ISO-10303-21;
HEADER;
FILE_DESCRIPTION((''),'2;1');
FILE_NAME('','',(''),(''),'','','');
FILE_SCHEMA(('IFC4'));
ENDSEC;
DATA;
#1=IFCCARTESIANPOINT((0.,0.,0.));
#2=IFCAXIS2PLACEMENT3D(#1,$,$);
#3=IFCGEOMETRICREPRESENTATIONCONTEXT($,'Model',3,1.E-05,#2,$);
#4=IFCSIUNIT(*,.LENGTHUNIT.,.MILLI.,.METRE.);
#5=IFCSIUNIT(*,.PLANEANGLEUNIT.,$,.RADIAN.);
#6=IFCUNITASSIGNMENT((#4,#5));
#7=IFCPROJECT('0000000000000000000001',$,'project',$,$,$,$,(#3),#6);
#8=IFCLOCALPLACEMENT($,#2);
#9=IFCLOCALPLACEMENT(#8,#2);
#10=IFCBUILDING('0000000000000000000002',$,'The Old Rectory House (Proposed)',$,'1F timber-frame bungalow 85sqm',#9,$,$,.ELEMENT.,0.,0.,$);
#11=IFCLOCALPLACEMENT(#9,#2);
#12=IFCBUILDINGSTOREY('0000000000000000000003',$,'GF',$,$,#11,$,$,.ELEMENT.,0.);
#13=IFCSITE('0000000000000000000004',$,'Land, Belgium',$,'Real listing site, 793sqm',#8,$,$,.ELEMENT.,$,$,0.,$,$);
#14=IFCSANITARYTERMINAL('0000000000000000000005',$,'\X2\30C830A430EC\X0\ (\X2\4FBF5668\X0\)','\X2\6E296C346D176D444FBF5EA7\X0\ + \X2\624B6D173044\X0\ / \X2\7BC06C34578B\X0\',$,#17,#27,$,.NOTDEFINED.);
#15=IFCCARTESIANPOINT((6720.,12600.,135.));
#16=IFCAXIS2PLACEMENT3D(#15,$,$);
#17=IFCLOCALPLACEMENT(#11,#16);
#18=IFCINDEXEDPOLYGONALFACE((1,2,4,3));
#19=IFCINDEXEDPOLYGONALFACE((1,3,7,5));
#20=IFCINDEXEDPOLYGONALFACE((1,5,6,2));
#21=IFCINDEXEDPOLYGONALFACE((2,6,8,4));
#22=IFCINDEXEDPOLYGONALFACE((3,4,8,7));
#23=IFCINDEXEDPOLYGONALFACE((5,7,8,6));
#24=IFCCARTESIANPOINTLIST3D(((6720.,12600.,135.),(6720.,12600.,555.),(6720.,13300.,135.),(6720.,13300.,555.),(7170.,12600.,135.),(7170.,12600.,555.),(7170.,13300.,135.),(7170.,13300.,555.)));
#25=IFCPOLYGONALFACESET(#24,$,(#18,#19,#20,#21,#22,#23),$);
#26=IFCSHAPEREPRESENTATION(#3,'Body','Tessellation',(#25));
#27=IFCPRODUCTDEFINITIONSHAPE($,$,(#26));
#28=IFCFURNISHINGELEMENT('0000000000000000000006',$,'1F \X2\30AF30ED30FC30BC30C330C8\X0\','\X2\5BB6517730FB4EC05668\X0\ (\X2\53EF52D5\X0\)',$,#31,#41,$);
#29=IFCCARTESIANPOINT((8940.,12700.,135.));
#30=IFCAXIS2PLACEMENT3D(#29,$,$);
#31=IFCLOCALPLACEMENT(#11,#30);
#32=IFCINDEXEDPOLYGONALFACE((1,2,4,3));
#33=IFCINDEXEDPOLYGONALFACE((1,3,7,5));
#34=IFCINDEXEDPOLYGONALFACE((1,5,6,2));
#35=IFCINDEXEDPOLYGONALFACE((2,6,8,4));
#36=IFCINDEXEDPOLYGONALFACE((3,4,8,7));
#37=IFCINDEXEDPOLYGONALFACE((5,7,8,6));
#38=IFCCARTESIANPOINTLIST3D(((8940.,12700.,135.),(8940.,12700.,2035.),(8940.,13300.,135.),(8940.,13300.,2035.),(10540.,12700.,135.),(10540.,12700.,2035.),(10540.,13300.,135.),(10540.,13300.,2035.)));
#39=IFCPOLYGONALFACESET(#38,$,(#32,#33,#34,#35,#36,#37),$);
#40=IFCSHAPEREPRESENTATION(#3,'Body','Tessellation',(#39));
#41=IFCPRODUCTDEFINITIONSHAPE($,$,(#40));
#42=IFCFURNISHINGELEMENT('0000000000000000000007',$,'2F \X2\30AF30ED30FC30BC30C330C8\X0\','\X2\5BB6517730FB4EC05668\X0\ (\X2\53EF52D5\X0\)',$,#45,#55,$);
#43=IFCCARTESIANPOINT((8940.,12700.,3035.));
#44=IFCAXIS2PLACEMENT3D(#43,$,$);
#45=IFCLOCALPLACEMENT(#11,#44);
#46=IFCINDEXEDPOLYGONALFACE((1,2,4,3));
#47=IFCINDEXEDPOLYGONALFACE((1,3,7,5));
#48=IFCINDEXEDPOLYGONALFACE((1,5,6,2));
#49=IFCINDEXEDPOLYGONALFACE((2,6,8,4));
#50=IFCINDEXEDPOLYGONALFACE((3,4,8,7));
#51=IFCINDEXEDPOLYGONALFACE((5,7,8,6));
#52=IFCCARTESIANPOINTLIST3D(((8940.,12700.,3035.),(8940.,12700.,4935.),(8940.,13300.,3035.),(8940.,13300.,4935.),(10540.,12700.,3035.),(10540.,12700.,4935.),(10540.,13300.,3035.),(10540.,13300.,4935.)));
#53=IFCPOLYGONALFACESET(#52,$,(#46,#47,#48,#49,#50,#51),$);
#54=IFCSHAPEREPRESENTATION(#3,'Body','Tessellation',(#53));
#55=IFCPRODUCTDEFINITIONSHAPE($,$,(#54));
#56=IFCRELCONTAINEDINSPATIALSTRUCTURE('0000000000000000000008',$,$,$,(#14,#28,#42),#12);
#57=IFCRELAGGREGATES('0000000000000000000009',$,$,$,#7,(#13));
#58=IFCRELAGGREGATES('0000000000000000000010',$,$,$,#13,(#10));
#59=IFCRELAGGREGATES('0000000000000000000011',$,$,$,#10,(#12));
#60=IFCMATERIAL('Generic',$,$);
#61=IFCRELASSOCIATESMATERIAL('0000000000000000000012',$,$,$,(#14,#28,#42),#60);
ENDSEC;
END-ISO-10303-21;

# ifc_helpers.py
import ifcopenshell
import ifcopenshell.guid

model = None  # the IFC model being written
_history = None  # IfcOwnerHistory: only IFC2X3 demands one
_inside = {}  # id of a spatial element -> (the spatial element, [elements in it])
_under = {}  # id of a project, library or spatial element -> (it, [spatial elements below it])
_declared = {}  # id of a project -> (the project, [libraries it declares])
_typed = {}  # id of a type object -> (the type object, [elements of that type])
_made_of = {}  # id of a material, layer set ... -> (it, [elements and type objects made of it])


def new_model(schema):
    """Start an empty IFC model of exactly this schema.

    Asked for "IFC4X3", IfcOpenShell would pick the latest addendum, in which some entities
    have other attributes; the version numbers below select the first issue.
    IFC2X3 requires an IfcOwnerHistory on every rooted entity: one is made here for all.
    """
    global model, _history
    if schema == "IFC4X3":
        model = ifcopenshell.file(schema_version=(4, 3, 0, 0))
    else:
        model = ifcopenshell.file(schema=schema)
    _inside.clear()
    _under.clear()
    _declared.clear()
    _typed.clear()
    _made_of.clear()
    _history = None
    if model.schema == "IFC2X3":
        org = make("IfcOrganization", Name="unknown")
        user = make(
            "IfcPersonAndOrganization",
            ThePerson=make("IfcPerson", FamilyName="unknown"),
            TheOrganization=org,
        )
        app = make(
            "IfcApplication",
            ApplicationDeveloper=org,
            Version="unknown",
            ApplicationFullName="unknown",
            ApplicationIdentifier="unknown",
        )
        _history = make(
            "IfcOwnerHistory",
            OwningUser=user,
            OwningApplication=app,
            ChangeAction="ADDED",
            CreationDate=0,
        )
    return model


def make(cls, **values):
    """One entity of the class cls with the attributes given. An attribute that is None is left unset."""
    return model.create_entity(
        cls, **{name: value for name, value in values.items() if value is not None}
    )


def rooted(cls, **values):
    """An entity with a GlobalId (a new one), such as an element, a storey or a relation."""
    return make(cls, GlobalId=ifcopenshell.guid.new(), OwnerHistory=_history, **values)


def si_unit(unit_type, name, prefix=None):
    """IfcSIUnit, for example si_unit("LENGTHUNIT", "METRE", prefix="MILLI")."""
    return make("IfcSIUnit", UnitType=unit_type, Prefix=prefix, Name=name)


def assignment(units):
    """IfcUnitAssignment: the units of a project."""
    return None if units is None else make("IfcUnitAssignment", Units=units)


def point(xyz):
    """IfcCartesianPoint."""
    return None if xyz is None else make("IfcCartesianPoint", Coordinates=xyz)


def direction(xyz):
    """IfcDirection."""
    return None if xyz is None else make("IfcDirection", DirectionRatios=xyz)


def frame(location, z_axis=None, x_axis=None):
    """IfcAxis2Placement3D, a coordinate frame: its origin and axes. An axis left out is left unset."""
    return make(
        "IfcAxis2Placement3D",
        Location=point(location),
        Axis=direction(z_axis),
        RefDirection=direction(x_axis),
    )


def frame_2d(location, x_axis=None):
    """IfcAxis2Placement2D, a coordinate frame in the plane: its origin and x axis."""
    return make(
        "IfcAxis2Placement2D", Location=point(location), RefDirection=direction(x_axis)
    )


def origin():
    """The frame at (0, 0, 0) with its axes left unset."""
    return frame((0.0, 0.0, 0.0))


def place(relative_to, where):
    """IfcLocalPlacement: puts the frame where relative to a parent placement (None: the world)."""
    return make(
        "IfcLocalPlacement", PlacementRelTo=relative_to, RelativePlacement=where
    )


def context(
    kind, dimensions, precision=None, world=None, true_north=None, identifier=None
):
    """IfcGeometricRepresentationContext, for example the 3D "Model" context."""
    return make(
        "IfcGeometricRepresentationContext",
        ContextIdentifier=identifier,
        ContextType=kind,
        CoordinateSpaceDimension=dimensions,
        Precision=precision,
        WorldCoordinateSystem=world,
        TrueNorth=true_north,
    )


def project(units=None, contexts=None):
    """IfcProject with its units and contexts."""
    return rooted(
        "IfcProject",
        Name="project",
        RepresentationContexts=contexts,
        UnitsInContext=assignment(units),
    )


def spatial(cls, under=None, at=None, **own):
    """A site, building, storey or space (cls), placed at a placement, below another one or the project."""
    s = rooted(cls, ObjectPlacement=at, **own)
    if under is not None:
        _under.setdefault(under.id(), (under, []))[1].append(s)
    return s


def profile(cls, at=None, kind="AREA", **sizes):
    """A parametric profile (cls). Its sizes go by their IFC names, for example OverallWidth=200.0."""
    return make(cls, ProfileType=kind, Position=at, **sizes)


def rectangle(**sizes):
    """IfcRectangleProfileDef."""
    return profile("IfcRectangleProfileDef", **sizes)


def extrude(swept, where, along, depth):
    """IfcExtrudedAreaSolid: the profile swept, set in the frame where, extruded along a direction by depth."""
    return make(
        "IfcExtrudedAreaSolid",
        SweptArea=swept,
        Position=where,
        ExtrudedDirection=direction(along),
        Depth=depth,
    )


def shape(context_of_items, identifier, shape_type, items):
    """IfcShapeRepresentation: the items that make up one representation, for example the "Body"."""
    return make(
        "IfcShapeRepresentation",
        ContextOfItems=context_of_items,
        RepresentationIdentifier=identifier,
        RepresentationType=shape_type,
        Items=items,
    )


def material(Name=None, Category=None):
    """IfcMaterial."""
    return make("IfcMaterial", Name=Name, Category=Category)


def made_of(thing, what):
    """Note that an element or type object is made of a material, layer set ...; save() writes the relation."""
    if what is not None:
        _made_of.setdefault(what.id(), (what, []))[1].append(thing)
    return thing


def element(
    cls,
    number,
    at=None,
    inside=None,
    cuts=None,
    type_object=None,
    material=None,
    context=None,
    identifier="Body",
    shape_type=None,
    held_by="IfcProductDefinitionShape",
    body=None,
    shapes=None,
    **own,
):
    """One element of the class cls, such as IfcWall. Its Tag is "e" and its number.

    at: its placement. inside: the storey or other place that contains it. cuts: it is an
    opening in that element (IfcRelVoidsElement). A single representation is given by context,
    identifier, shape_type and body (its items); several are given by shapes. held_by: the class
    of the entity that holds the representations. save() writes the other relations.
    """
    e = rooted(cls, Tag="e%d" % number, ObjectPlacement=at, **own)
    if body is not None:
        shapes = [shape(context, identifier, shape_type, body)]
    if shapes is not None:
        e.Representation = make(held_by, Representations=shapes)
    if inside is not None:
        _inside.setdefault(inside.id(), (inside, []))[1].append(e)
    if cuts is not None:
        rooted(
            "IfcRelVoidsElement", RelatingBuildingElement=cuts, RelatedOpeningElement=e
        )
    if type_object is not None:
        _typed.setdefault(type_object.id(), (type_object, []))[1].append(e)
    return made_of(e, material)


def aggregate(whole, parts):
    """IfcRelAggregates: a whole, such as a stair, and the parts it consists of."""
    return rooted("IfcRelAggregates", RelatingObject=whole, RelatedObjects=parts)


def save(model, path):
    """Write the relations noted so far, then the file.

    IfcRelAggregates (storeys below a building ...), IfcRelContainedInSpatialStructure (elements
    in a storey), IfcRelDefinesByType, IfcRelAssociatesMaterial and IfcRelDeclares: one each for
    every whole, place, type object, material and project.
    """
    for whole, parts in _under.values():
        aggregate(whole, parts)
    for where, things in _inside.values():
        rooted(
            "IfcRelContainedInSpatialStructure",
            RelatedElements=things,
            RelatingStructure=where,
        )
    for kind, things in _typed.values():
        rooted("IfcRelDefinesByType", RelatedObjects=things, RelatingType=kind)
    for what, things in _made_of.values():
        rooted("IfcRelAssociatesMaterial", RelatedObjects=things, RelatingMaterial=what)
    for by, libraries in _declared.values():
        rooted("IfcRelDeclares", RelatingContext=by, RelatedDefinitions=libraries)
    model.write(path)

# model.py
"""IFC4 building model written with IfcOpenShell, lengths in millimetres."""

from ifc_helpers import new_model, si_unit, frame, frame_2d, origin, place, context, project, spatial, rectangle, extrude, material, element, save


model = new_model("IFC4")

# Units and contexts
model_context = context("Model", 3, precision=1e-05, world=origin())
ifc_project = project(units=[si_unit("LENGTHUNIT", "METRE", prefix="MILLI"), si_unit("PLANEANGLEUNIT", "RADIAN")], contexts=[model_context])

# Site, building, storey
site_placement = place(None, origin())
site = spatial("IfcSite", under=ifc_project, at=site_placement, Name="Land, Belgium", ObjectType="Real listing site, 793sqm", CompositionType="ELEMENT", RefElevation=0.0)
building_placement = place(site_placement, origin())
building = spatial("IfcBuilding", under=site, at=building_placement, Name="The Old Rectory House (Proposed)", ObjectType="1F timber-frame bungalow 85sqm", CompositionType="ELEMENT", ElevationOfRefHeight=0.0, ElevationOfTerrain=0.0)
storey_placement = place(building_placement, origin())
storey = spatial("IfcBuildingStorey", under=building, at=storey_placement, Name="GF", CompositionType="ELEMENT", Elevation=0.0)

# Sanitary terminal
ifc_material_1 = material(Name="Generic")
sanitary_terminal_1_placement = place(storey_placement, frame((6720.0, 12600.0, 135.0)))
element("IfcSanitaryTerminal", 1, at=sanitary_terminal_1_placement, inside=storey, material=ifc_material_1, Name="トイレ (便器)", Description="温水洗浄便座 + 手洗い / 節水型", PredefinedType="NOTDEFINED", context=model_context, shape_type="SweptSolid", body=[
    extrude(rectangle(XDim=450.0, YDim=700.0, at=frame_2d((225.0, 350.0))), frame((6720.0, 12600.0, 135.0)), (0.0, 0.0, 1.0), 420.0),
])

# Furnishing elements
furnishing_1_placement = place(storey_placement, frame((8940.0, 12700.0, 135.0)))
element("IfcFurnishingElement", 2, at=furnishing_1_placement, inside=storey, material=ifc_material_1, Name="1F クローゼット", Description="家具・什器 (可動)", context=model_context, shape_type="SweptSolid", body=[
    extrude(rectangle(XDim=1600.0, YDim=600.0, at=frame_2d((800.0, 300.0))), frame((8940.0, 12700.0, 135.0)), (0.0, 0.0, 1.0), 1900.0),
])
furnishing_2_placement = place(storey_placement, frame((8940.0, 12700.0, 3035.0)))
element("IfcFurnishingElement", 3, at=furnishing_2_placement, inside=storey, material=ifc_material_1, Name="2F クローゼット", Description="家具・什器 (可動)", context=model_context, shape_type="SweptSolid", body=[
    extrude(rectangle(XDim=1600.0, YDim=600.0, at=frame_2d((800.0, 300.0))), frame((8940.0, 12700.0, 3035.0)), (0.0, 0.0, 1.0), 1900.0),
])

save(model, "model.ifc")
